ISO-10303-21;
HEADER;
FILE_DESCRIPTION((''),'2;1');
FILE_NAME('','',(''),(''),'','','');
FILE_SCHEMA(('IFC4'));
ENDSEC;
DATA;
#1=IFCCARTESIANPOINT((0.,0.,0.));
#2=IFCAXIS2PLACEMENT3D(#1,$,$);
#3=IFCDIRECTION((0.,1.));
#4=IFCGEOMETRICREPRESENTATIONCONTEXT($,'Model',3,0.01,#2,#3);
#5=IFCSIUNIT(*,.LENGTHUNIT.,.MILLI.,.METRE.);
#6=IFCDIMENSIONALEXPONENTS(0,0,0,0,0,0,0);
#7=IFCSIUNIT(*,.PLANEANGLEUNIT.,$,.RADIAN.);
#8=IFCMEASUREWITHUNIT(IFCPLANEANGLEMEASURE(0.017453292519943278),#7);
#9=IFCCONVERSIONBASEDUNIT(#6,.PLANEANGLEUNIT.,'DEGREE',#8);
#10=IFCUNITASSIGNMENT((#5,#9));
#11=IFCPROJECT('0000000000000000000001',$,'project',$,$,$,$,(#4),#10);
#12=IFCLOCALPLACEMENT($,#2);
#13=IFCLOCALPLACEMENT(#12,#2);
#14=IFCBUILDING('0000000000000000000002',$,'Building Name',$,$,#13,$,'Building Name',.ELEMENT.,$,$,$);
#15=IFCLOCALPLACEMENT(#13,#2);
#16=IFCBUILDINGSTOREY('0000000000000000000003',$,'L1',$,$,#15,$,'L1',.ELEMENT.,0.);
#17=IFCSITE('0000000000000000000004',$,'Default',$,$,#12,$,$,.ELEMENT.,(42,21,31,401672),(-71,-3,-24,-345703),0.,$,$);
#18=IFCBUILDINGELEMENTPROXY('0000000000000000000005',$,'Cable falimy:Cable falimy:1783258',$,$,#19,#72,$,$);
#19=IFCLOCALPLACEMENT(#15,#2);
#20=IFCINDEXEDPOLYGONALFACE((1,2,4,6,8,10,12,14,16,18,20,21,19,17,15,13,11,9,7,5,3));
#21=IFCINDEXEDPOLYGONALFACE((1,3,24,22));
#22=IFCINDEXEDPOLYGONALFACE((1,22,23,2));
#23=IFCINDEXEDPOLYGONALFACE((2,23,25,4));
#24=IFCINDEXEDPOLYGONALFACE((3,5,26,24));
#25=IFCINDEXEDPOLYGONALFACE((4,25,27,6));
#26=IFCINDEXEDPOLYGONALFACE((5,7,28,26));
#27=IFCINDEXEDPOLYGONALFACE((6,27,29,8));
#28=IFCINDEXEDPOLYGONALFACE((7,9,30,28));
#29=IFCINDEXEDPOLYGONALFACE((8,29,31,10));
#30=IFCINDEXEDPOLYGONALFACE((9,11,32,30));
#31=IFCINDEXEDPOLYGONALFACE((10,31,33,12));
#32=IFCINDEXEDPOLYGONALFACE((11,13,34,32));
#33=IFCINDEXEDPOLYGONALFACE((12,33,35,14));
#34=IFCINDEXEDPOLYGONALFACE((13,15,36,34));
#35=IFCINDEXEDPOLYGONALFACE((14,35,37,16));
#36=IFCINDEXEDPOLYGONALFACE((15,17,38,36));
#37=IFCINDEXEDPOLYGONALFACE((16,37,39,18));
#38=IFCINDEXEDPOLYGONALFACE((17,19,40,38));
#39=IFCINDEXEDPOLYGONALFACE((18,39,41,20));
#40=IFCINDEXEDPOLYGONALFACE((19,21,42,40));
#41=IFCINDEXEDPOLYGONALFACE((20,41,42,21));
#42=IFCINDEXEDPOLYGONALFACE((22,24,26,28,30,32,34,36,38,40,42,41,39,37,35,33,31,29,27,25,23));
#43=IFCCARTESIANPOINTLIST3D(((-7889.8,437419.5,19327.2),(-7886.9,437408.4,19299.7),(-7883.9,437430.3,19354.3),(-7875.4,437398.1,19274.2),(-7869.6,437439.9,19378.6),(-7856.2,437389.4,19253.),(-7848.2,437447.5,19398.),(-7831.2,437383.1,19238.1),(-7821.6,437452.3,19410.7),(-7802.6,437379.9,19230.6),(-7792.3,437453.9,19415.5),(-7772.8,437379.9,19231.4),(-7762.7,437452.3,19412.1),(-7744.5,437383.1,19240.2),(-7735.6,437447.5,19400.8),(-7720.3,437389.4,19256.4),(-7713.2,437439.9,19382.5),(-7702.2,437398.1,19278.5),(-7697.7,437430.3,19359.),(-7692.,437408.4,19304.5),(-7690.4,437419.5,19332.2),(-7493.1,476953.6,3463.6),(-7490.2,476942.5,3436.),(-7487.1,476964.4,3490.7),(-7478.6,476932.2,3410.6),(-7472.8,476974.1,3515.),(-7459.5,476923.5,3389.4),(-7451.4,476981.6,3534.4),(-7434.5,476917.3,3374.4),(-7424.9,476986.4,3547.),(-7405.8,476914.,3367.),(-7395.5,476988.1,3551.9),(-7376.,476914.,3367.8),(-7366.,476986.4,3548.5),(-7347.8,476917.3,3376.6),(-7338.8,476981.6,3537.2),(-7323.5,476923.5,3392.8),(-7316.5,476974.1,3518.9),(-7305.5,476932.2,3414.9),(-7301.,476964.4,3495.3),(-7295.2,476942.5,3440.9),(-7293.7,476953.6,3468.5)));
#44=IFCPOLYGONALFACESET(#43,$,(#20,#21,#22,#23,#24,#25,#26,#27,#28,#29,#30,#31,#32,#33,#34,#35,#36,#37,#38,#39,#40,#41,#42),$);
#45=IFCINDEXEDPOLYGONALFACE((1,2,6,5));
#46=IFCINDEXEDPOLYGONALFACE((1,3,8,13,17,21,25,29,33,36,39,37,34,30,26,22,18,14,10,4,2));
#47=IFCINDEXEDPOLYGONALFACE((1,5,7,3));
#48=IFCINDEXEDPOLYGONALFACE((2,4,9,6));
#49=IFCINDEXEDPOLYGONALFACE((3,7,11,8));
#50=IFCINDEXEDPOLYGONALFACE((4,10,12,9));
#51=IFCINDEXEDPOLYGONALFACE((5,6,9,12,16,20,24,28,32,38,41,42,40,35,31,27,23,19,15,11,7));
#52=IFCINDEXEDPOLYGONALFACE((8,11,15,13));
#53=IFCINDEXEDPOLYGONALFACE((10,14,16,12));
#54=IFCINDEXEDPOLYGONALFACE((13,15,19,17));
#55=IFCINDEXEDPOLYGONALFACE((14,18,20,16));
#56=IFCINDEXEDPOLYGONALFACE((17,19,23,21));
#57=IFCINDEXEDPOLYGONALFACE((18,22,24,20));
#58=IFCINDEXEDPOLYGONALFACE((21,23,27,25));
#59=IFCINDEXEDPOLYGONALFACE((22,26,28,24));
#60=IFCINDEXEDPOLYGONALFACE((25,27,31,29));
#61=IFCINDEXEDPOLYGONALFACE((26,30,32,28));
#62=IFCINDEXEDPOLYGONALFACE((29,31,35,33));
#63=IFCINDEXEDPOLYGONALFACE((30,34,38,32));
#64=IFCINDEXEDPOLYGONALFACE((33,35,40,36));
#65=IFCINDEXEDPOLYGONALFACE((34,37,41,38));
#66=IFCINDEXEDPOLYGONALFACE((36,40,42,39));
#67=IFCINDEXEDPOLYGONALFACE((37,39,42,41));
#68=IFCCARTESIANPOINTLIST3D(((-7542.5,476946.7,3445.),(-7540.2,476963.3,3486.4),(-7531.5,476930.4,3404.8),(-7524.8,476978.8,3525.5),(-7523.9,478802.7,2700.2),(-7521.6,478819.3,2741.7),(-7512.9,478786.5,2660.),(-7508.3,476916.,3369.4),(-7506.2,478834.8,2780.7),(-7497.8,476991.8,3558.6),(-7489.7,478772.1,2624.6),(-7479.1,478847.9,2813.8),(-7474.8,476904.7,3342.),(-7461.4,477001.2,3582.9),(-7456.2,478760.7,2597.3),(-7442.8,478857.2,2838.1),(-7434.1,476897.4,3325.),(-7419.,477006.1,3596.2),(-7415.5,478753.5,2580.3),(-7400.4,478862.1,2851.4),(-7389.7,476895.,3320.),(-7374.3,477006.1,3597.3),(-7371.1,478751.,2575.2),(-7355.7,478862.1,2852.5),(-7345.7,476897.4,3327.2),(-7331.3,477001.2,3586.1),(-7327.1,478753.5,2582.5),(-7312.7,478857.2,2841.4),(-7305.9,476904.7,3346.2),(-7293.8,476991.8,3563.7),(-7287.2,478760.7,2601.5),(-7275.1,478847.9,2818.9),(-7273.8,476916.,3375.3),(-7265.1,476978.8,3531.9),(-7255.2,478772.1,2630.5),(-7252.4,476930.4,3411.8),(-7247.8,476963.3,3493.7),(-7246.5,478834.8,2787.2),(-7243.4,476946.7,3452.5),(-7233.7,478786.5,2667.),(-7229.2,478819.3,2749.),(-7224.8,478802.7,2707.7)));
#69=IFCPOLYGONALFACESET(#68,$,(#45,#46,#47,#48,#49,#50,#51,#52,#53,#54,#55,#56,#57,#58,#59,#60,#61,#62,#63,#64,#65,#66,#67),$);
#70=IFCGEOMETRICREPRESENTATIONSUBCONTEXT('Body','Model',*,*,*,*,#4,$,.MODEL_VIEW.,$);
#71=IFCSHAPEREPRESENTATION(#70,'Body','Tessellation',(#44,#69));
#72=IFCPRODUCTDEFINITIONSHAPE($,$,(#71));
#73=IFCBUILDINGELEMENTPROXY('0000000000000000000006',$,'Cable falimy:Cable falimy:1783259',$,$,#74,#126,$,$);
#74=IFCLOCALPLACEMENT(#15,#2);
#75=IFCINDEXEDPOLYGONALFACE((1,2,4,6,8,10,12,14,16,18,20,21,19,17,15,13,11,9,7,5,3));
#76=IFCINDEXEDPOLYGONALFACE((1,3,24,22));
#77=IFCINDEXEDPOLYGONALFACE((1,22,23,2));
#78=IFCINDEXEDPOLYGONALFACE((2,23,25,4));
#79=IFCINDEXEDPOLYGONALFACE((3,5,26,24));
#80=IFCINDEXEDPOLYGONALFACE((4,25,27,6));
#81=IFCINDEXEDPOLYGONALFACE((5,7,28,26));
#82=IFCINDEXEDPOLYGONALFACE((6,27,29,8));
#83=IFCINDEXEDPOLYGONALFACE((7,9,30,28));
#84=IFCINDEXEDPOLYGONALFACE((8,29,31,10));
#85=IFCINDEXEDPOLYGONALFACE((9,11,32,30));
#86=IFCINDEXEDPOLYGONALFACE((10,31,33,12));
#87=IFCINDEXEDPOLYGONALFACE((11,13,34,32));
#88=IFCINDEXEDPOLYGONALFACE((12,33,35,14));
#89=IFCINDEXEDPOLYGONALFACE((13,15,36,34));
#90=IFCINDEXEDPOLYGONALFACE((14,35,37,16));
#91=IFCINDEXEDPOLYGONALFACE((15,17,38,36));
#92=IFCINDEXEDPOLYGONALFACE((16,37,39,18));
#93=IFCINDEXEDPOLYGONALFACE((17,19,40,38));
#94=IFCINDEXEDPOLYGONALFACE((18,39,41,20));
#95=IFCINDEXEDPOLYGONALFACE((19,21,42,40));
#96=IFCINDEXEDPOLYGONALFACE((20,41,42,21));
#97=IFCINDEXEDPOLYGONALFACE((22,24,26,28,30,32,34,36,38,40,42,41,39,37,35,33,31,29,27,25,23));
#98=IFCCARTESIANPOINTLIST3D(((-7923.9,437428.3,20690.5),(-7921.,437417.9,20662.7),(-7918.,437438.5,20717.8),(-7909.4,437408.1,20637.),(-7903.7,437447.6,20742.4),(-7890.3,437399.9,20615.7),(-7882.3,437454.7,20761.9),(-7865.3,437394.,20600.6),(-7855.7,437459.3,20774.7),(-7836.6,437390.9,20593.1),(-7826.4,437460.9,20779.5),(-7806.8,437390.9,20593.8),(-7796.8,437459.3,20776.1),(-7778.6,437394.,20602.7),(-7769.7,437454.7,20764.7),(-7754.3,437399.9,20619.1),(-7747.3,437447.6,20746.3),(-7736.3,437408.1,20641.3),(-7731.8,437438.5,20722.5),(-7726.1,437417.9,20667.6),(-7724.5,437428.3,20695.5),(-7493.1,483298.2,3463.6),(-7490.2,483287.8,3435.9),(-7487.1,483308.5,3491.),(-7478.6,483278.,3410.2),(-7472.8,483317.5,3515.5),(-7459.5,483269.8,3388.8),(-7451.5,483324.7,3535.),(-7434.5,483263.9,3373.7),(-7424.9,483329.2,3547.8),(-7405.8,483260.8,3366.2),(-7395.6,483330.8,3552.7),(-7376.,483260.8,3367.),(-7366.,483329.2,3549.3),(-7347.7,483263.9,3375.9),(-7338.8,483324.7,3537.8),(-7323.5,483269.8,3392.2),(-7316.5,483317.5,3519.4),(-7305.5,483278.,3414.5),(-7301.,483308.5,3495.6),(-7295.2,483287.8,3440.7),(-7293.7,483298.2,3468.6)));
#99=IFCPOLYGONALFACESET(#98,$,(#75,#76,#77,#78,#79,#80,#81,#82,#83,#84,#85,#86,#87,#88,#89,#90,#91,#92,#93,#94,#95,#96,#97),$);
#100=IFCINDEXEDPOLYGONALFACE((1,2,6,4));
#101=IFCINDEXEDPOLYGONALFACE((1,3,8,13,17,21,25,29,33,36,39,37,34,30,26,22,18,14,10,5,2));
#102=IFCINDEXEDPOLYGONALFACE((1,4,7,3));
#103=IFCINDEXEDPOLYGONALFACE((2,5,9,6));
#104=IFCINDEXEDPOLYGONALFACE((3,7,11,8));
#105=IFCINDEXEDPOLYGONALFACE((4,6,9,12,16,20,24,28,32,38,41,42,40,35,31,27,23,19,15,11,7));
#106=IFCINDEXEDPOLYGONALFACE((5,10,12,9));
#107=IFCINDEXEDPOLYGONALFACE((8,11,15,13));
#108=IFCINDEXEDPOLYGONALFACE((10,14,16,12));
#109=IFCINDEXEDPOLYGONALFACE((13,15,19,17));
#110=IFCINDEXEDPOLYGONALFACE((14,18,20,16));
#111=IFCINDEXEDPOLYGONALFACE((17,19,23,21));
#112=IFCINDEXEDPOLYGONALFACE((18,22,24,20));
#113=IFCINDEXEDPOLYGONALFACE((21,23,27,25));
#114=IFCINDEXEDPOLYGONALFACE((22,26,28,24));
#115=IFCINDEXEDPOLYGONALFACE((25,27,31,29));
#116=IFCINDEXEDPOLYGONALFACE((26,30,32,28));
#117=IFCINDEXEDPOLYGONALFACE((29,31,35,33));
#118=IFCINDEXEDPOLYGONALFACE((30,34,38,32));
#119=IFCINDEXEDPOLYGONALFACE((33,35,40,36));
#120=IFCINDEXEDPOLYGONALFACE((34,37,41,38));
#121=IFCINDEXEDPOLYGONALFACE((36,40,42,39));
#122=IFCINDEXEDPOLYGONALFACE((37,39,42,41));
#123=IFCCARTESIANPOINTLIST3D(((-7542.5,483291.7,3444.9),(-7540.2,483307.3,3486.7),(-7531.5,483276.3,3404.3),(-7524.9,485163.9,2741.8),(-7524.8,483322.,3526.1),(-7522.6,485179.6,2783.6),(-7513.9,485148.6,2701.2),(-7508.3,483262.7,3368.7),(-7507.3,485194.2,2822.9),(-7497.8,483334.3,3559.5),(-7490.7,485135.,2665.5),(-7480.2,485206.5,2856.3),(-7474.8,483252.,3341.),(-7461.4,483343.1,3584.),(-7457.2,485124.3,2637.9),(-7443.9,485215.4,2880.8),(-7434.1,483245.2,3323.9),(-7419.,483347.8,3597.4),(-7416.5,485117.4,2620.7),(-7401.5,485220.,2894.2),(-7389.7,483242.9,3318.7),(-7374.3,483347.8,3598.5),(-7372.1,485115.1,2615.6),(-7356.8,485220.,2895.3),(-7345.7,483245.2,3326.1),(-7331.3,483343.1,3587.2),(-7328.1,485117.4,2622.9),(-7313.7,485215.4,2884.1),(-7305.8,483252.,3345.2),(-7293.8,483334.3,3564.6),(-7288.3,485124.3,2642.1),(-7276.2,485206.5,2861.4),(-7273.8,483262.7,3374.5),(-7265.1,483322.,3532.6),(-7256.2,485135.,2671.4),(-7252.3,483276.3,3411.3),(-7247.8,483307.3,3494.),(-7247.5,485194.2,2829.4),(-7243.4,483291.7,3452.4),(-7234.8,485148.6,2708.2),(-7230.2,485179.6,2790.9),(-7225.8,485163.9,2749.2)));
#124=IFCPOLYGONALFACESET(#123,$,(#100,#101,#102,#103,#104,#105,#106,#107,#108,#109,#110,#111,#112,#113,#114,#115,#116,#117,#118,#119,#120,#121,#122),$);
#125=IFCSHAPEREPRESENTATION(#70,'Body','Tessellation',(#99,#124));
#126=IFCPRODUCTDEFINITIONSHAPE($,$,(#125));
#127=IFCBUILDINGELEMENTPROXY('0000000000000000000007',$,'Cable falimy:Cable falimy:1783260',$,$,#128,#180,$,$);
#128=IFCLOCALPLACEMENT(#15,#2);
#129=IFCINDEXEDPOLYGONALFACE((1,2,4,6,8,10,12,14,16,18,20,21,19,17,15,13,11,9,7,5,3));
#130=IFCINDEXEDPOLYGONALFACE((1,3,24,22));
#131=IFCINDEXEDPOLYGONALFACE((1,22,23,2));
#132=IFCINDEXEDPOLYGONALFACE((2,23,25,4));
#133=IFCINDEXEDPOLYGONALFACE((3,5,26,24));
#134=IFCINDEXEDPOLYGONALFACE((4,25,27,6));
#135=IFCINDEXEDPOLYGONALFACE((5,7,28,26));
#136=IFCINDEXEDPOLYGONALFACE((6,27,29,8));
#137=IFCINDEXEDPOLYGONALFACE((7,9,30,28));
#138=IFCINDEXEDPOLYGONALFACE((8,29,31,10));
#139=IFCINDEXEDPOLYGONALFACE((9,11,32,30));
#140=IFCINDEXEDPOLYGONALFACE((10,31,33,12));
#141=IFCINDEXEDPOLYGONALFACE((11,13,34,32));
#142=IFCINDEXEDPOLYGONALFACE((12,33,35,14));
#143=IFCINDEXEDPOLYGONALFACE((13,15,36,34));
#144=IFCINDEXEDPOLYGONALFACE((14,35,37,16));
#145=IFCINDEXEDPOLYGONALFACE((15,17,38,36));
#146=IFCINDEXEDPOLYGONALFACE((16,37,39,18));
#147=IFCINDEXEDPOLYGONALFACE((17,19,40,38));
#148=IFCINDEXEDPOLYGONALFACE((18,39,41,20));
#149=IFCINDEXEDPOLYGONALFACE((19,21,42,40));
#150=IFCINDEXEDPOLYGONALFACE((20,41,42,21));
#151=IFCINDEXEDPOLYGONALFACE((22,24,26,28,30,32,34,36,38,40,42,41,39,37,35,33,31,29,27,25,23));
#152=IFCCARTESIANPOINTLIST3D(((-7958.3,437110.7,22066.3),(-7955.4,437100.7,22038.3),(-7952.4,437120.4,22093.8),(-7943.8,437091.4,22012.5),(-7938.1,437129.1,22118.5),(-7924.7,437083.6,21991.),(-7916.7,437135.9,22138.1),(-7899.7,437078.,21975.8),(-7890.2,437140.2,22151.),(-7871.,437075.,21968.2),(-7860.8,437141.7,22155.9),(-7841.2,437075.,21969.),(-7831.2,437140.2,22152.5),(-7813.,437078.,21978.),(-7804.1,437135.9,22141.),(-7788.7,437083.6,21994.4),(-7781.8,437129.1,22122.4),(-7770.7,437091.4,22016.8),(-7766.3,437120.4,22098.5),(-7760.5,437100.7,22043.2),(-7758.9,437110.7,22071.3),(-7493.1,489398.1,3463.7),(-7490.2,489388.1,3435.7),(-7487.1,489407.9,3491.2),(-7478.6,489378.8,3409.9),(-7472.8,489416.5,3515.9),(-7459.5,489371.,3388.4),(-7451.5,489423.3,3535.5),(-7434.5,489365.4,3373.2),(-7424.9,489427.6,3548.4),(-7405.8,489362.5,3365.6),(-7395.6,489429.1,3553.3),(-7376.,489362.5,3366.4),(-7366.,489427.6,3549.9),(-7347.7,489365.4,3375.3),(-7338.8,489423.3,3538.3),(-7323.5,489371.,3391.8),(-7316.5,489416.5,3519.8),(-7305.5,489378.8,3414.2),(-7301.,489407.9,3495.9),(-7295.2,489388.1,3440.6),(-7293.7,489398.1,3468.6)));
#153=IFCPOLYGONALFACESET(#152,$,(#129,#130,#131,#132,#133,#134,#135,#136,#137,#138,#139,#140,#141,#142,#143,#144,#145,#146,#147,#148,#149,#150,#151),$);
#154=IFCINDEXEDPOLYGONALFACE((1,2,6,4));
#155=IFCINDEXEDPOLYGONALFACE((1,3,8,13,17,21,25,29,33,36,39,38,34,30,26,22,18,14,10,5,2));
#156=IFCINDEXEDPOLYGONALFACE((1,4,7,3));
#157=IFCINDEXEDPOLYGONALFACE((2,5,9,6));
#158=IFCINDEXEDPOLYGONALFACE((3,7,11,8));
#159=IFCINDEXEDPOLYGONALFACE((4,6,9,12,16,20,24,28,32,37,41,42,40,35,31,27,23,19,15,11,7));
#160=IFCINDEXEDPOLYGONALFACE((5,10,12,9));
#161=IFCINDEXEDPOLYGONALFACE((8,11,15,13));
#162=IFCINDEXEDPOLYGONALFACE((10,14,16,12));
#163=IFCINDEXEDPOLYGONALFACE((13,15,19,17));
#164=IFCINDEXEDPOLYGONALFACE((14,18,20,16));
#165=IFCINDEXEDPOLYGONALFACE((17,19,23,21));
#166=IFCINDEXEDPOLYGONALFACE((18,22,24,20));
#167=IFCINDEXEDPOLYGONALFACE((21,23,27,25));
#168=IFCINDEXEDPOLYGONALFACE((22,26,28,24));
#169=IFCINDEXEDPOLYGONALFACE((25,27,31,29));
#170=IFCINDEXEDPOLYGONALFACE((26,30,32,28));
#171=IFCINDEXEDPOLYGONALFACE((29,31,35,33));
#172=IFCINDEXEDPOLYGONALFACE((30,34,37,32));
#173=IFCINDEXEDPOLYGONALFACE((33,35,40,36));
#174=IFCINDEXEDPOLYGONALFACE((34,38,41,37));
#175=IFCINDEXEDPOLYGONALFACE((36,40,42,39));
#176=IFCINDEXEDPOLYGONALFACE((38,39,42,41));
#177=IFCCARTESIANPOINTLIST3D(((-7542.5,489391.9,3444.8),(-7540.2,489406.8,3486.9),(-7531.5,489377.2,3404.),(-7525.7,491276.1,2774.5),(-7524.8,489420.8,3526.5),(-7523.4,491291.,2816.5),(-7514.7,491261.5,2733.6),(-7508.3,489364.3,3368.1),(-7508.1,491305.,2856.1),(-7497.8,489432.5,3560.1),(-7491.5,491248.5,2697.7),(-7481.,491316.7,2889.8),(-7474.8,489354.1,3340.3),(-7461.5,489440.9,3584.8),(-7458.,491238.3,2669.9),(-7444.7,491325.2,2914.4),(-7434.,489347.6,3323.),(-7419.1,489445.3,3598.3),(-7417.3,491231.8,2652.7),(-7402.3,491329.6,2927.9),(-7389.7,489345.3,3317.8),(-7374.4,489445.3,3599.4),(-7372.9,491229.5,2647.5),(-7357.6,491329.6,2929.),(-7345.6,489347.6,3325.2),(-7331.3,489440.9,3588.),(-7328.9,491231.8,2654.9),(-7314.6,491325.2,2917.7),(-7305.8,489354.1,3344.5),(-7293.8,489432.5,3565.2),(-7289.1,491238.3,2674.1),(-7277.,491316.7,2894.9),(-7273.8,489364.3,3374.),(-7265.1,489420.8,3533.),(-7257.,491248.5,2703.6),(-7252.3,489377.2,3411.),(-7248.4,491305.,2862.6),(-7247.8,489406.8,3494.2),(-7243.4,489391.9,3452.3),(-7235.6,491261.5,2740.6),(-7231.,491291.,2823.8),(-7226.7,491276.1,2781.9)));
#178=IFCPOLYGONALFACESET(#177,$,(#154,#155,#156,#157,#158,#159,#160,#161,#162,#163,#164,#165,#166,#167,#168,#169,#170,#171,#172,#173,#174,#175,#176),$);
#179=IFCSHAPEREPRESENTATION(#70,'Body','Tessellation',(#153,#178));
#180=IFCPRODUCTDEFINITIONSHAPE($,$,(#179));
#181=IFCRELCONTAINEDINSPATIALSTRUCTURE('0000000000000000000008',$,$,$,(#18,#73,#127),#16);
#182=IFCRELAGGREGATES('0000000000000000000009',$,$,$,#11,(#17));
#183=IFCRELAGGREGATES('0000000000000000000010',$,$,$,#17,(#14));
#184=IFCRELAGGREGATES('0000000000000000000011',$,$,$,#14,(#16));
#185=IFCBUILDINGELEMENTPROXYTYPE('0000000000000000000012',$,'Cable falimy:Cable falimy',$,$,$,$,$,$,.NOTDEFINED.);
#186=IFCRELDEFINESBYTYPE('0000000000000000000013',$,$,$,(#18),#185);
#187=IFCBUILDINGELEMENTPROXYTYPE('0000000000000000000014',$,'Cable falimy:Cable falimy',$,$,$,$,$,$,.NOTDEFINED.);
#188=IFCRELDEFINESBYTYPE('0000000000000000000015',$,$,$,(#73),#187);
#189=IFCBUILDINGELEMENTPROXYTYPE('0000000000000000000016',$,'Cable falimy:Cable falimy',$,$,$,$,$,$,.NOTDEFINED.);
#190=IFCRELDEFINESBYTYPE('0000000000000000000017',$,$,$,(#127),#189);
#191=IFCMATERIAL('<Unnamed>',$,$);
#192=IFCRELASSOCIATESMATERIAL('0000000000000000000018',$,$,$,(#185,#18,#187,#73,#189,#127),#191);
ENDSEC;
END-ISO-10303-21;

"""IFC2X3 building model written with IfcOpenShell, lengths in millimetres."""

from ifc_helpers import new_model, entity, si_unit, converted_unit, direction, frame, frame_2d, origin, place, context, subcontext, project, spatial, circle, extrude, source, transform, mapped, material, type_object, type_shapes, element, save


model = new_model("IFC2X3")

# Units and contexts
model_context = context("Model", 3, precision=0.01, world=origin(), true_north=direction((0.0, 1.0)))
body_context = subcontext(model_context, "Body", "Model", "MODEL_VIEW")
ifc_project = project(units=[si_unit("LENGTHUNIT", "METRE", prefix="MILLI"), converted_unit("PLANEANGLEUNIT", "DEGREE", entity("IfcPlaneAngleMeasure", 0.017453292519943278), si_unit("PLANEANGLEUNIT", "RADIAN"), dimensions=[0, 0, 0, 0, 0, 0, 0])], contexts=[model_context])

# Site, building, storey
site_placement = place(None, origin())
site = spatial("IfcSite", under=ifc_project, at=site_placement, Name="Default", CompositionType="ELEMENT", RefLatitude=(42, 21, 31, 401672), RefLongitude=(-71, -3, -24, -345703), RefElevation=0.0)
building_placement = place(site_placement, origin())
building = spatial("IfcBuilding", under=site, at=building_placement, Name="Building Name", LongName="Building Name", CompositionType="ELEMENT")
storey_placement = place(building_placement, origin())
storey = spatial("IfcBuildingStorey", under=building, at=storey_placement, Name="L1", LongName="L1", CompositionType="ELEMENT", Elevation=0.0)

# Shared definitions
ifc_material = material(Name="<Unnamed>")

# Building element proxies
building_element_proxy_type_1 = type_object("IfcBuildingElementProxyType", Name="Cable falimy:Cable falimy", PredefinedType="NOTDEFINED", material=ifc_material)
shared_shape_1 = source(origin(), body_context, "Body", "SweptSolid", [
    extrude(circle(Radius=100.0, at=frame_2d((0.0, 0.0), x_axis=(1.0, 0.0))), frame((0.0, 0.0, 0.0), z_axis=(0.928031, 0.0, 0.372502), x_axis=(-0.372502, 0.0, 0.928031)), (0.0, 0.0, 1.0), 42600.0),
    extrude(circle(Radius=150.0, at=frame_2d((0.0, 0.0), x_axis=(1.0, 0.0))), frame((-1856.1, 0.0, -745.0), z_axis=(0.928031, 0.0, 0.372502), x_axis=(0.372502, 0.0, -0.928031)), (0.0, 0.0, 1.0), 2000.0),
])
type_shapes(building_element_proxy_type_1, [shared_shape_1])
proxy_1_placement = place(storey_placement, frame((-7393.2, 476950.8, 3459.1), z_axis=(-0.025001, 0.0, 0.999687), x_axis=(0.0, -1.0, 0.0)))
element("IfcBuildingElementProxy", 1, at=proxy_1_placement, inside=storey, type_object=building_element_proxy_type_1, material=ifc_material, Name="Cable falimy:Cable falimy:1783258", context=body_context, shape_type="MappedRepresentation", body=[
    mapped(shared_shape_1, transform((0.0, 0.0, 0.0), scale=1.0)),
])
building_element_proxy_type_2 = type_object("IfcBuildingElementProxyType", Name="Cable falimy:Cable falimy", PredefinedType="NOTDEFINED", material=ifc_material)
shared_shape_2 = source(origin(), body_context, "Body", "SweptSolid", [
    extrude(circle(Radius=100.0, at=frame_2d((0.0, 0.0), x_axis=(1.0, 0.0))), frame((0.0, 0.0, 0.0), z_axis=(0.936121, 0.0, 0.351678), x_axis=(-0.351678, 0.0, 0.936121)), (0.0, 0.0, 1.0), 49000.0),
    extrude(circle(Radius=150.0, at=frame_2d((0.0, 0.0), x_axis=(1.0, 0.0))), frame((-1872.2, 0.0, -703.4), z_axis=(0.936121, 0.0, 0.351678), x_axis=(0.351678, 0.0, -0.936121)), (0.0, 0.0, 1.0), 2000.0),
])
type_shapes(building_element_proxy_type_2, [shared_shape_2])
proxy_2_placement = place(storey_placement, frame((-7393.2, 483295.6, 3459.1), z_axis=(-0.025001, 0.0, 0.999687), x_axis=(0.0, -1.0, 0.0)))
element("IfcBuildingElementProxy", 2, at=proxy_2_placement, inside=storey, type_object=building_element_proxy_type_2, material=ifc_material, Name="Cable falimy:Cable falimy:1783259", context=body_context, shape_type="MappedRepresentation", body=[
    mapped(shared_shape_2, transform((0.0, 0.0, 0.0), scale=1.0)),
])
building_element_proxy_type_3 = type_object("IfcBuildingElementProxyType", Name="Cable falimy:Cable falimy", PredefinedType="NOTDEFINED", material=ifc_material)
shared_shape_3 = source(origin(), body_context, "Body", "SweptSolid", [
    extrude(circle(Radius=100.0, at=frame_2d((0.0, 0.0), x_axis=(1.0, 0.0))), frame((0.0, 0.0, 0.0), z_axis=(0.942116, 0.0, 0.335287), x_axis=(-0.335287, 0.0, 0.942116)), (0.0, 0.0, 1.0), 55500.0),
    extrude(circle(Radius=150.0, at=frame_2d((0.0, 0.0), x_axis=(1.0, 0.0))), frame((-1884.2, 0.0, -670.6), z_axis=(0.942116, 0.0, 0.335287), x_axis=(0.335287, 0.0, -0.942116)), (0.0, 0.0, 1.0), 2000.0),
])
type_shapes(building_element_proxy_type_3, [shared_shape_3])
proxy_3_placement = place(storey_placement, frame((-7393.2, 489395.6, 3459.1), z_axis=(-0.025001, 0.0, 0.999687), x_axis=(0.0, -1.0, 0.0)))
element("IfcBuildingElementProxy", 3, at=proxy_3_placement, inside=storey, type_object=building_element_proxy_type_3, material=ifc_material, Name="Cable falimy:Cable falimy:1783260", context=body_context, shape_type="MappedRepresentation", body=[
    mapped(shared_shape_3, transform((0.0, 0.0, 0.0), scale=1.0)),
])

save(model, "model.ifc")
